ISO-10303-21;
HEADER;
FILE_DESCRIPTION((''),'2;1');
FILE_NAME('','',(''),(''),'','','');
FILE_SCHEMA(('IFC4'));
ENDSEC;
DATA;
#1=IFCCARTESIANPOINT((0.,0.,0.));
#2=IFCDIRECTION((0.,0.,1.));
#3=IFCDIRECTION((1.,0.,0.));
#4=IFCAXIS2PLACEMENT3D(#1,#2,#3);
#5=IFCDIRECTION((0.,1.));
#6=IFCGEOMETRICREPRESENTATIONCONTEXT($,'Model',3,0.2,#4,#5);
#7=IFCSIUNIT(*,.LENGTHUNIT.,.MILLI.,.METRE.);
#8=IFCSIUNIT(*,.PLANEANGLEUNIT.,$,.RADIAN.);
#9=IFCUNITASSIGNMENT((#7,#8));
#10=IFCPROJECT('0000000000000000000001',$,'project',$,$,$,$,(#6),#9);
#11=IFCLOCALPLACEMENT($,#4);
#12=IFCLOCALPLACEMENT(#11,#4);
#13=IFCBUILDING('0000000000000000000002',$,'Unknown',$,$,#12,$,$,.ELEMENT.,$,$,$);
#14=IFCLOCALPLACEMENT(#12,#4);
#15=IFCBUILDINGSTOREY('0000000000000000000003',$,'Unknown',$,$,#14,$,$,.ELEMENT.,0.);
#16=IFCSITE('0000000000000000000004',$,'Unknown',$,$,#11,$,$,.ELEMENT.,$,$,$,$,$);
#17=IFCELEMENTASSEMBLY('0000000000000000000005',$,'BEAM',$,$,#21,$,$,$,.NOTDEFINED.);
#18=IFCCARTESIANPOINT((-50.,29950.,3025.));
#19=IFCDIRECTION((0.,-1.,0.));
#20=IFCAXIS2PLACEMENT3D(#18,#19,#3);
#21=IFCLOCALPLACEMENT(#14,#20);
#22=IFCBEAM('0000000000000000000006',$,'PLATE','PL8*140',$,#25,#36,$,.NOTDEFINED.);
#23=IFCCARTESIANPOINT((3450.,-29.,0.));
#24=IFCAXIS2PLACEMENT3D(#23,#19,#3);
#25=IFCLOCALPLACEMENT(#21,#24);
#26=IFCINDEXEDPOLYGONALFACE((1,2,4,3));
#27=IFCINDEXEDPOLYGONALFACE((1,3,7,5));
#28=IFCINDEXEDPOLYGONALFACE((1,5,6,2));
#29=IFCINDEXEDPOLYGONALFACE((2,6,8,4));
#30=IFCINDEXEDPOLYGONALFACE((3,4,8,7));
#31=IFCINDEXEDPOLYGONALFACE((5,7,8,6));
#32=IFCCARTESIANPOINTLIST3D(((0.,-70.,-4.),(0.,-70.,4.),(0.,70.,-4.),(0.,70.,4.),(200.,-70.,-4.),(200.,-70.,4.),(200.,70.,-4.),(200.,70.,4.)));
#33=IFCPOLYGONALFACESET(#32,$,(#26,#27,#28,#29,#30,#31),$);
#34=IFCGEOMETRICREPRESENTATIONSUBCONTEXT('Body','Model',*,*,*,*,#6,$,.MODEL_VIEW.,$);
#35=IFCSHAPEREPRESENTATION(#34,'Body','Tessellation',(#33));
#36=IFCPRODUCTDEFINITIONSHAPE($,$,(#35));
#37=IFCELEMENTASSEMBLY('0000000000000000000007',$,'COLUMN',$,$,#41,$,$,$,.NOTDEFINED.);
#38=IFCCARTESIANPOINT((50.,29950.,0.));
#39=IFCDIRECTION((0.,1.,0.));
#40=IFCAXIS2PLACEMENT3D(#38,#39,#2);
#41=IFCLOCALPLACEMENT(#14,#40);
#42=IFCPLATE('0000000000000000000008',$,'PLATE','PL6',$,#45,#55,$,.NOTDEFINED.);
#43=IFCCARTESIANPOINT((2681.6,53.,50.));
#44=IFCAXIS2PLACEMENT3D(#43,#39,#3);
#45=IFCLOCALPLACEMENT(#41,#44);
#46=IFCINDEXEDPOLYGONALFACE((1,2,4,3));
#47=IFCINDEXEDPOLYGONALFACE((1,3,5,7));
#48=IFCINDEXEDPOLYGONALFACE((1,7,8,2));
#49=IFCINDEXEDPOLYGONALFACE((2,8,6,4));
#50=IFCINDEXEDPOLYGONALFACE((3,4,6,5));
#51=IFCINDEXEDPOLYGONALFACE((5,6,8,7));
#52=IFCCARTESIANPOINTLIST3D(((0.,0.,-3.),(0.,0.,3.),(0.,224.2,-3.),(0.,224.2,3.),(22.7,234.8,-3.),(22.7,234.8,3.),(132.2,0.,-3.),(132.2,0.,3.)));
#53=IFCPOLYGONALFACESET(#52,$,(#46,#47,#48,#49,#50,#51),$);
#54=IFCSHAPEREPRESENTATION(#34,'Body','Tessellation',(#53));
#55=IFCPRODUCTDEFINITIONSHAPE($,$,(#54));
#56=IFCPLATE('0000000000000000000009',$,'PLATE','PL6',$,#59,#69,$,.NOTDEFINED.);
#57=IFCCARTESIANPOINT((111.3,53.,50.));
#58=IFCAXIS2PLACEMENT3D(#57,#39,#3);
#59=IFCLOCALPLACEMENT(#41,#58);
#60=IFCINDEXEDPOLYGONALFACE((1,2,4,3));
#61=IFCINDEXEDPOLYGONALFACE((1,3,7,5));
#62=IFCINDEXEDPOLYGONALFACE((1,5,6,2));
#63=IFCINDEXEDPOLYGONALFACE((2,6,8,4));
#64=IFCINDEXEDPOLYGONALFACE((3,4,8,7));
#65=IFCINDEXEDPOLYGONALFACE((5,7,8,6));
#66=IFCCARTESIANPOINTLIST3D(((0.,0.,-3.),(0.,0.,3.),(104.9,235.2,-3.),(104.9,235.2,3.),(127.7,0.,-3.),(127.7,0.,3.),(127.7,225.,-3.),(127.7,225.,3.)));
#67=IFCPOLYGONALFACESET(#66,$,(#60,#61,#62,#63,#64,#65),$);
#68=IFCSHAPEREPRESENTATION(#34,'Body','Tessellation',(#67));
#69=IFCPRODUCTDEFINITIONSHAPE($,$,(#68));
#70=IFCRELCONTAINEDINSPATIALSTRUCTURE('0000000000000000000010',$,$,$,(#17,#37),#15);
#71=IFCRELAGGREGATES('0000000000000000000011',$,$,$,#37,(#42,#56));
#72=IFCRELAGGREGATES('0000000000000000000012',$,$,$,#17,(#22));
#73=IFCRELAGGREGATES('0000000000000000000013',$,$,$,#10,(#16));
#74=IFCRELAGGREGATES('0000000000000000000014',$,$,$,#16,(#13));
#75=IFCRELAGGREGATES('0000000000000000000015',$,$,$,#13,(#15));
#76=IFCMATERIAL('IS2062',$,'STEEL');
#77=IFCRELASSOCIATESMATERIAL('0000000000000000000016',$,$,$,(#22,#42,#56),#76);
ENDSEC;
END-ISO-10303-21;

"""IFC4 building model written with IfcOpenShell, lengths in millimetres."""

from ifc_helpers import new_model, si_unit, direction, frame, origin_with_axes, place, context, subcontext, project, spatial, line, indexed_curve, outline, extrude, material, element, aggregate, save


model = new_model("IFC4")

# Units and contexts
model_context = context("Model", 3, precision=0.2, world=origin_with_axes(), true_north=direction((0.0, 1.0)))
body_context = subcontext(model_context, "Body", "Model", "MODEL_VIEW")
ifc_project = project(units=[si_unit("LENGTHUNIT", "METRE", prefix="MILLI"), si_unit("PLANEANGLEUNIT", "RADIAN")], contexts=[model_context])

# Site, building, storey
site_placement = place(None, origin_with_axes())
site = spatial("IfcSite", under=ifc_project, at=site_placement, Name="Unknown", CompositionType="ELEMENT")
building_placement = place(site_placement, origin_with_axes())
building = spatial("IfcBuilding", under=site, at=building_placement, Name="Unknown", CompositionType="ELEMENT")
storey_placement = place(building_placement, origin_with_axes())
storey = spatial("IfcBuildingStorey", under=building, at=storey_placement, Name="Unknown", CompositionType="ELEMENT", Elevation=0.0)

# Shared definitions
ifc_material_1 = material(Name="IS2062", Category="STEEL")

# Element assembly, beam
assembly_1_placement = place(storey_placement, frame((-50.0, 29950.0, 3025.0), z_axis=(0.0, -1.0, 0.0), x_axis=(1.0, 0.0, 0.0)))
assembly_1 = element("IfcElementAssembly", 1, at=assembly_1_placement, inside=storey, Name="BEAM", PredefinedType="NOTDEFINED")
beam_1_placement = place(assembly_1_placement, frame((3450.0, -29.0, 0.0), z_axis=(0.0, -1.0, 0.0), x_axis=(1.0, 0.0, 0.0)))
beam_1 = element("IfcBeam", 2, at=beam_1_placement, material=ifc_material_1, Name="PLATE", Description="PL8*140", PredefinedType="NOTDEFINED", context=body_context, shape_type="SolidModel", body=[
    extrude(outline(indexed_curve([(-4.0, -70.0), (4.0, -70.0), (4.0, 70.0), (-4.0, 70.0)], segments=[line(1, 2, 3, 4, 1)])), frame((0.0, 0.0, 0.0), z_axis=(-1.0, 0.0, 0.0), x_axis=(0.0, 0.0, 1.0)), (0.0, 0.0, -1.0), 200.0),
])

# Element assembly, plates
assembly_2_placement = place(storey_placement, frame((50.0, 29950.0, 0.0), z_axis=(0.0, 1.0, 0.0), x_axis=(0.0, 0.0, 1.0)))
assembly_2 = element("IfcElementAssembly", 3, at=assembly_2_placement, inside=storey, Name="COLUMN", PredefinedType="NOTDEFINED")
plate_1_placement = place(assembly_2_placement, frame((2681.6, 53.0, 50.0), z_axis=(0.0, 1.0, 0.0), x_axis=(1.0, 0.0, 0.0)))
plate_1 = element("IfcPlate", 4, at=plate_1_placement, material=ifc_material_1, Name="PLATE", Description="PL6", PredefinedType="NOTDEFINED", context=body_context, shape_type="SolidModel", body=[
    extrude(outline(indexed_curve([(0.0, 0.0), (132.2, 0.0), (22.7, 234.8), (0.0, 224.2)], segments=[line(1, 2, 3, 4, 1)])), frame((0.0, 0.0, 3.0), z_axis=(0.0, 0.0, 1.0), x_axis=(1.0, 0.0, 0.0)), (0.0, 0.0, -1.0), 6.0),
])
plate_2_placement = place(assembly_2_placement, frame((111.3, 53.0, 50.0), z_axis=(0.0, 1.0, 0.0), x_axis=(1.0, 0.0, 0.0)))
plate_2 = element("IfcPlate", 5, at=plate_2_placement, material=ifc_material_1, Name="PLATE", Description="PL6", PredefinedType="NOTDEFINED", context=body_context, shape_type="SolidModel", body=[
    extrude(outline(indexed_curve([(0.0, 0.0), (127.7, 0.0), (127.7, 225.0), (104.9, 235.2)], segments=[line(1, 2, 3, 4, 1)])), frame((0.0, 0.0, 3.0), z_axis=(0.0, 0.0, 1.0), x_axis=(1.0, 0.0, 0.0)), (0.0, 0.0, -1.0), 6.0),
])
aggregate(assembly_2, [plate_1, plate_2])

aggregate(assembly_1, [beam_1])

save(model, "model.ifc")
